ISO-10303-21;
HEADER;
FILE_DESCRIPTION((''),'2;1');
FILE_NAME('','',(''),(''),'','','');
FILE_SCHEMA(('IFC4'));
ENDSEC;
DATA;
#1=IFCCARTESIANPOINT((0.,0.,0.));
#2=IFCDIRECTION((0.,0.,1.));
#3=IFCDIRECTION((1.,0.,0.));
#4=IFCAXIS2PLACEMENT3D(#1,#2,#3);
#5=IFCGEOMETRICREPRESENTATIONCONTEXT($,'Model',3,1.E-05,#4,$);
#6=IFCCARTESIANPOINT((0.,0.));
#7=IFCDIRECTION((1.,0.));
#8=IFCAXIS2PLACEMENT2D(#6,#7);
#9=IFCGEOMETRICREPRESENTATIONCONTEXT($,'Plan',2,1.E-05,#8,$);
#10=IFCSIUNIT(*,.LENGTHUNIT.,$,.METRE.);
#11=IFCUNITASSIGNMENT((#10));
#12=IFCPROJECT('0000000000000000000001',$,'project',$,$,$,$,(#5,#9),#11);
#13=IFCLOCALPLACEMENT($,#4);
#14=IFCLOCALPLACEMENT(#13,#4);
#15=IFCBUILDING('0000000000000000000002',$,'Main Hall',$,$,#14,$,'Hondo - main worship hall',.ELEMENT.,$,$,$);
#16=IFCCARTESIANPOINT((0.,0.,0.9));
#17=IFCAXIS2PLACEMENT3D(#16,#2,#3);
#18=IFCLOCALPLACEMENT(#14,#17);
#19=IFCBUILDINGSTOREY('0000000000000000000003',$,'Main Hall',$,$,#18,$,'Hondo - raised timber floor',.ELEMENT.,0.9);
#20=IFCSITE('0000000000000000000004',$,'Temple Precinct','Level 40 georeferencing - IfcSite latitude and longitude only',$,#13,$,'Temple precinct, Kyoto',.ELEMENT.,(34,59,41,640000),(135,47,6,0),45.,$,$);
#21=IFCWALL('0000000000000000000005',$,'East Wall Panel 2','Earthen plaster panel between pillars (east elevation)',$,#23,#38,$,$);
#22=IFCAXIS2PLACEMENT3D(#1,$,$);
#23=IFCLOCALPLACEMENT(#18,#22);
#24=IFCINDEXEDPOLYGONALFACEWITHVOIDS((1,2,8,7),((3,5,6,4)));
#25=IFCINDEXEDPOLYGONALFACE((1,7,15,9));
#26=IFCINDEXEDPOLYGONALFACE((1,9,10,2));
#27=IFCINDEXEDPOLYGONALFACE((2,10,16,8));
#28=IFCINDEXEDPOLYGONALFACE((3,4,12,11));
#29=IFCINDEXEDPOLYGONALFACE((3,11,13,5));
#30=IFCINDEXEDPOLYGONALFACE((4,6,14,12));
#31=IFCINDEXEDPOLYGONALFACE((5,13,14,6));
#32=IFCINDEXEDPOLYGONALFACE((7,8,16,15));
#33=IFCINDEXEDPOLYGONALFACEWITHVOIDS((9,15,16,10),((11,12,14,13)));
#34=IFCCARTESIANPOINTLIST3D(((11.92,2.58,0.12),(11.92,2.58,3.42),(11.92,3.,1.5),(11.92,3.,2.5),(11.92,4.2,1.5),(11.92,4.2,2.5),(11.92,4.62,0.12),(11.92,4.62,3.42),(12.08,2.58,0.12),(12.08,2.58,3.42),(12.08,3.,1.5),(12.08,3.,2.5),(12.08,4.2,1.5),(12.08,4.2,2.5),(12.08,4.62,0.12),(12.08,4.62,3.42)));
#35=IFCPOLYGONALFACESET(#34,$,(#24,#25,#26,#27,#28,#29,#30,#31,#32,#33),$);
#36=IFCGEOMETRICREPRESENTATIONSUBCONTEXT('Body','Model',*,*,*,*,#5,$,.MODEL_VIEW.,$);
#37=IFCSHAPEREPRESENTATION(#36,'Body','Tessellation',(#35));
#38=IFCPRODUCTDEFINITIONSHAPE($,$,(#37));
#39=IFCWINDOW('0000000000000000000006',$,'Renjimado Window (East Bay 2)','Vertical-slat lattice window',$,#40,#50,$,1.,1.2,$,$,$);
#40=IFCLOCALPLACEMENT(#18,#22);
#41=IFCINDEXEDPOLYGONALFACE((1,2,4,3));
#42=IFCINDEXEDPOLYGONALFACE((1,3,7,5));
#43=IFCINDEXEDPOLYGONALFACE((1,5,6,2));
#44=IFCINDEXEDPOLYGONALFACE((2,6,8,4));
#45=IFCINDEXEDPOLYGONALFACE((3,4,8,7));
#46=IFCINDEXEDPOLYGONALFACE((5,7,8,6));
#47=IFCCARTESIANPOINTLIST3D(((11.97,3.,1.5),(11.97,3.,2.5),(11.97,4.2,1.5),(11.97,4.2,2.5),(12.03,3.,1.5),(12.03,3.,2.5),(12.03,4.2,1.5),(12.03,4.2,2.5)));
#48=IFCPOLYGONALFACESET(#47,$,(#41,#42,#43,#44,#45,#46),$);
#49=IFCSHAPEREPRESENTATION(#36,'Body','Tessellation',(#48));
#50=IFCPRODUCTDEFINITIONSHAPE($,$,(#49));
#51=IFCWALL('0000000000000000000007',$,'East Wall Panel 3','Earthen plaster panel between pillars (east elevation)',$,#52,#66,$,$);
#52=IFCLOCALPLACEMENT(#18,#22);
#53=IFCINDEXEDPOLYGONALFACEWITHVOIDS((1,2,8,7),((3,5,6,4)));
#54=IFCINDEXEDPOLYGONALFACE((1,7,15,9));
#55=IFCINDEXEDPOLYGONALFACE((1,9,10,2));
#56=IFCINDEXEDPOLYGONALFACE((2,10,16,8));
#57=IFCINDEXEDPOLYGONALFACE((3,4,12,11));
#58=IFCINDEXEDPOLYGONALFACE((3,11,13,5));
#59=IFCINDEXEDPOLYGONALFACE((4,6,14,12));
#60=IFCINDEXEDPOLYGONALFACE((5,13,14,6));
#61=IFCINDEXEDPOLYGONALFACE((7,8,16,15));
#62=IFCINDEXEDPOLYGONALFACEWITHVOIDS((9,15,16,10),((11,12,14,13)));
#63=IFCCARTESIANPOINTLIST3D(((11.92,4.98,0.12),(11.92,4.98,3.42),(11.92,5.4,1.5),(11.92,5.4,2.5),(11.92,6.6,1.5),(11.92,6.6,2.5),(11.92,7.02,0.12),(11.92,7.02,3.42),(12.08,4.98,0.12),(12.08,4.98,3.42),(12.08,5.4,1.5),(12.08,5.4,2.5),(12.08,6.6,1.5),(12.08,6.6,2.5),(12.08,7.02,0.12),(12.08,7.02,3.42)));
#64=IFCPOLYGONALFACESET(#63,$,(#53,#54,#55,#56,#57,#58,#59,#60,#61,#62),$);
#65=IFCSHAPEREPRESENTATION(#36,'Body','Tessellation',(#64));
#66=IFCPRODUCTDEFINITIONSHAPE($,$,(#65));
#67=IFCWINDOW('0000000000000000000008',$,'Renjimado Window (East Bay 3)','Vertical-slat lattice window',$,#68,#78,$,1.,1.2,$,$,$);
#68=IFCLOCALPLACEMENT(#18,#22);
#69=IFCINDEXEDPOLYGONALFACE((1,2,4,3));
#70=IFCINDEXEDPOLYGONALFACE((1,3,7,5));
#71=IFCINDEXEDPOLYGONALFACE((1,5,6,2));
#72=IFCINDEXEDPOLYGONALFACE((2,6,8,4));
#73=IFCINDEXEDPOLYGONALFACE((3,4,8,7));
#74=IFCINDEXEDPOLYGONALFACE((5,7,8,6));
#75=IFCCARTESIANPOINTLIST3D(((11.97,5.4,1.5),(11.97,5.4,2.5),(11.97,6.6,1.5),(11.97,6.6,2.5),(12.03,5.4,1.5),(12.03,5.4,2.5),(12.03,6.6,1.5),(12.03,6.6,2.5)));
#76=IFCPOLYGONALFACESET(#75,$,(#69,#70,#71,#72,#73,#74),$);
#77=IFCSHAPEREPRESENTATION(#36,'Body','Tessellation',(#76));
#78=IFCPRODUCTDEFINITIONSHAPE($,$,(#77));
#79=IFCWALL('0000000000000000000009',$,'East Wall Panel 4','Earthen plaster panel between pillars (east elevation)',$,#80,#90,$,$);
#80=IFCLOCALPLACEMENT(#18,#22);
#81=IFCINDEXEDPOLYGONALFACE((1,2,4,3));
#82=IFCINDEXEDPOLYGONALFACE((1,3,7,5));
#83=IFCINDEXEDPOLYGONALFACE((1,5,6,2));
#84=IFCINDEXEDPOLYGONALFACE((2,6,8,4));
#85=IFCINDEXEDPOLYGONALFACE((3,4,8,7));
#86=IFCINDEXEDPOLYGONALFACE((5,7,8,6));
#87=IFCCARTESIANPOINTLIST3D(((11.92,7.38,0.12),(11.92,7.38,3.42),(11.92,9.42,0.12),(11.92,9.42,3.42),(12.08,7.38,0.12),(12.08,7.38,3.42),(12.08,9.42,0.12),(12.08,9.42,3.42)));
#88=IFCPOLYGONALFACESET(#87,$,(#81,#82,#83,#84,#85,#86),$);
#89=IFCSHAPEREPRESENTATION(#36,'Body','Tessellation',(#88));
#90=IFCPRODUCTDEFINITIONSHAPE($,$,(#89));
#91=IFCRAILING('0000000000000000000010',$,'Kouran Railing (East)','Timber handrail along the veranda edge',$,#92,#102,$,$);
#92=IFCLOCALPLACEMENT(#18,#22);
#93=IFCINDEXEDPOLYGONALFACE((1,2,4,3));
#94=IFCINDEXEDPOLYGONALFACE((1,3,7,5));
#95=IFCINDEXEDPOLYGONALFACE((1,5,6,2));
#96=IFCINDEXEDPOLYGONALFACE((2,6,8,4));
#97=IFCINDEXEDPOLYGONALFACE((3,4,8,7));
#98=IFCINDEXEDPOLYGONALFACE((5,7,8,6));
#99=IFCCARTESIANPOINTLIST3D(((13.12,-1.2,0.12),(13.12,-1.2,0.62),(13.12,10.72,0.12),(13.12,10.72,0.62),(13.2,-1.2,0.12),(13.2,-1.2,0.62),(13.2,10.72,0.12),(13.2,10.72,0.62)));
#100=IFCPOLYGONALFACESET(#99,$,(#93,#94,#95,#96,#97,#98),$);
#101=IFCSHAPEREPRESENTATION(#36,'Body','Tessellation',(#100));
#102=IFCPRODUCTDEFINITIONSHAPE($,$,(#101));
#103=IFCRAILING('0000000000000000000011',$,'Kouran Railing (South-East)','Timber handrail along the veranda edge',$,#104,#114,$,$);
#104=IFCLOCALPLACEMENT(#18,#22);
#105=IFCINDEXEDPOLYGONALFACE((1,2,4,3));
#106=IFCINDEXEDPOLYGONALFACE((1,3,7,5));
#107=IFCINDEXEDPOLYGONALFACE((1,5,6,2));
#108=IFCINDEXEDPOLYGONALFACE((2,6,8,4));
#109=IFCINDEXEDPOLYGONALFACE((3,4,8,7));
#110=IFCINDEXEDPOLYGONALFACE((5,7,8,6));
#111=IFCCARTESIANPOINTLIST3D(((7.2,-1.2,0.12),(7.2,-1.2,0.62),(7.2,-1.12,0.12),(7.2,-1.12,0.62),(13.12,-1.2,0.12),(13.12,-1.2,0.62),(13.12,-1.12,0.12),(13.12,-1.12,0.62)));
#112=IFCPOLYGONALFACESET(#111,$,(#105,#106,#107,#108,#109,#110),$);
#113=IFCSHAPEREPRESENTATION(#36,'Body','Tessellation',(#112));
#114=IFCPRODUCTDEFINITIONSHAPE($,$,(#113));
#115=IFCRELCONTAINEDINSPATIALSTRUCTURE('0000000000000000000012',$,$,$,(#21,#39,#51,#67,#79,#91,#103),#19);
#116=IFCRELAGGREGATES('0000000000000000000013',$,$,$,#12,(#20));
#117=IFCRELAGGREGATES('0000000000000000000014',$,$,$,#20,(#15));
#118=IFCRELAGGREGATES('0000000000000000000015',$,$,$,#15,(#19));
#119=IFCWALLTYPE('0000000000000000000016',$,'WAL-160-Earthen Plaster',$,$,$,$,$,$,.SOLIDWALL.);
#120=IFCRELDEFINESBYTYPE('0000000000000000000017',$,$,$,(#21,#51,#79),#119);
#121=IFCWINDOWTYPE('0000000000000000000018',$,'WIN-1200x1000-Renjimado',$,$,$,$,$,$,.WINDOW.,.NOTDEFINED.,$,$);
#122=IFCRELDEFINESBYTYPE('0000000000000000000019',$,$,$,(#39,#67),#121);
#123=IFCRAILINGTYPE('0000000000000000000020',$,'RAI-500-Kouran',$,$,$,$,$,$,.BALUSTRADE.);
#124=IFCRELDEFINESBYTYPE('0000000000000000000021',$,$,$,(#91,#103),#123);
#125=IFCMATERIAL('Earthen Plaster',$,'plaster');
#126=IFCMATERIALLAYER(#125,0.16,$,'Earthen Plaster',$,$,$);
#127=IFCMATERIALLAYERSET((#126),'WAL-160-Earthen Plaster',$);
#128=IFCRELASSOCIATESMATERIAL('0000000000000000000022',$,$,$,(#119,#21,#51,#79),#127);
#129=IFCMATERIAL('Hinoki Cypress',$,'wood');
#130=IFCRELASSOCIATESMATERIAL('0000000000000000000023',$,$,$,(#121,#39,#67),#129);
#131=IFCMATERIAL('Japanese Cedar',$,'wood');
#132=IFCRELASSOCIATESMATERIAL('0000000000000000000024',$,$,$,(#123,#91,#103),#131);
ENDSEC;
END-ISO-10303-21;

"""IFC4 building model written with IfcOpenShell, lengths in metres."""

from ifc_helpers import new_model, si_unit, frame, origin_with_axes, origin_2d_with_axis, place, context, subcontext, project, spatial, line, indexed_curve, outline, extrude, material, layer, layer_set, layer_usage, type_object, element, fill, save


model = new_model("IFC4")

# Units and contexts
model_context = context("Model", 3, precision=1e-05, world=origin_with_axes())
plan_context = context("Plan", 2, precision=1e-05, world=origin_2d_with_axis())
body_context = subcontext(model_context, "Body", "Model", "MODEL_VIEW")
ifc_project = project(units=[si_unit("LENGTHUNIT", "METRE")], contexts=[model_context, plan_context])

# Site, building, storey
site_placement = place(None, origin_with_axes())
site = spatial("IfcSite", under=ifc_project, at=site_placement, Name="Temple Precinct", Description="Level 40 georeferencing - IfcSite latitude and longitude only", LongName="Temple precinct, Kyoto", CompositionType="ELEMENT", RefLatitude=(34, 59, 41, 640000), RefLongitude=(135, 47, 6, 0), RefElevation=45.0)
building_placement = place(site_placement, origin_with_axes())
building = spatial("IfcBuilding", under=site, at=building_placement, Name="Main Hall", LongName="Hondo - main worship hall", CompositionType="ELEMENT")
storey_placement = place(building_placement, frame((0.0, 0.0, 0.9), z_axis=(0.0, 0.0, 1.0), x_axis=(1.0, 0.0, 0.0)))
storey = spatial("IfcBuildingStorey", under=building, at=storey_placement, Name="Main Hall", LongName="Hondo - raised timber floor", CompositionType="ELEMENT", Elevation=0.9)

# Shared definitions
ifc_material_1 = material(Name="Hinoki Cypress", Category="wood")

# Shared definitions
ifc_material_2 = material(Name="Japanese Cedar", Category="wood")

# Shared definitions
ifc_material_3 = material(Name="Earthen Plaster", Category="plaster")
ifc_layer_1 = layer(ifc_material_3, 0.16, Name="Earthen Plaster")
ifc_layer_set_1 = layer_set([ifc_layer_1], Name="WAL-160-Earthen Plaster")
wall_type = type_object("IfcWallType", Name="WAL-160-Earthen Plaster", PredefinedType="SOLIDWALL", material=ifc_layer_set_1)

# Walls, openings, windows
ifc_layer_usage_1 = layer_usage(ifc_layer_set_1, "AXIS2", "POSITIVE", 0.0)
wall_1_placement = place(storey_placement, frame((11.92, 4.62, 0.12), z_axis=(0.0, 0.0, 1.0), x_axis=(0.0, -1.0, 0.0)))
wall_1 = element("IfcWall", 1, at=wall_1_placement, inside=storey, type_object=wall_type, material=ifc_layer_usage_1, Name="East Wall Panel 2", Description="Earthen plaster panel between pillars (east elevation)", context=body_context, shape_type="SweptSolid", body=[
    extrude(outline(indexed_curve([(0.0, 0.0), (0.0, 0.16), (2.04, 0.16), (2.04, 0.0), (0.0, 0.0)], self_intersect=False)), origin_with_axes(), (0.0, 0.0, 1.0), 3.3),
])
opening_1_placement = place(wall_1_placement, frame((1.62, -0.01, 1.38), z_axis=(0.0, 0.0, 1.0), x_axis=(0.0, 1.0, 0.0)))
opening_1 = element("IfcOpeningElement", 2, at=opening_1_placement, cuts=wall_1, PredefinedType="OPENING", context=body_context, shape_type="SweptSolid", body=[
    extrude(outline(indexed_curve([(0.0, 0.0), (0.18, 0.0), (0.18, 1.2), (0.0, 1.2)], segments=[line(1, 2, 3, 4, 1)])), origin_with_axes(), (0.0, 0.0, 1.0), 1.0),
])
window_type = type_object("IfcWindowType", Name="WIN-1200x1000-Renjimado", PartitioningType="NOTDEFINED", PredefinedType="WINDOW", material=ifc_material_1)
window_1_placement = place(storey_placement, frame((11.97, 3.0, 1.5), z_axis=(0.0, 0.0, 1.0), x_axis=(1.0, 0.0, 0.0)))
window_1 = element("IfcWindow", 3, at=window_1_placement, inside=storey, type_object=window_type, material=ifc_material_1, Name="Renjimado Window (East Bay 2)", Description="Vertical-slat lattice window", OverallHeight=1.0, OverallWidth=1.2, context=body_context, shape_type="SweptSolid", body=[
    extrude(outline(indexed_curve([(0.0, 0.0), (0.06, 0.0), (0.06, 1.2), (0.0, 1.2)], segments=[line(1, 2, 3, 4, 1)])), origin_with_axes(), (0.0, 0.0, 1.0), 1.0),
])
fill(opening_1, window_1)
ifc_layer_usage_2 = layer_usage(ifc_layer_set_1, "AXIS2", "POSITIVE", 0.0)
wall_2_placement = place(storey_placement, frame((11.92, 7.02, 0.12), z_axis=(0.0, 0.0, 1.0), x_axis=(0.0, -1.0, 0.0)))
wall_2 = element("IfcWall", 4, at=wall_2_placement, inside=storey, type_object=wall_type, material=ifc_layer_usage_2, Name="East Wall Panel 3", Description="Earthen plaster panel between pillars (east elevation)", context=body_context, shape_type="SweptSolid", body=[
    extrude(outline(indexed_curve([(0.0, 0.0), (0.0, 0.16), (2.04, 0.16), (2.04, 0.0), (0.0, 0.0)], self_intersect=False)), origin_with_axes(), (0.0, 0.0, 1.0), 3.3),
])
opening_2_placement = place(wall_2_placement, frame((1.62, -0.01, 1.38), z_axis=(0.0, 0.0, 1.0), x_axis=(0.0, 1.0, 0.0)))
opening_2 = element("IfcOpeningElement", 5, at=opening_2_placement, cuts=wall_2, PredefinedType="OPENING", context=body_context, shape_type="SweptSolid", body=[
    extrude(outline(indexed_curve([(0.0, 0.0), (0.18, 0.0), (0.18, 1.2), (0.0, 1.2)], segments=[line(1, 2, 3, 4, 1)])), origin_with_axes(), (0.0, 0.0, 1.0), 1.0),
])
window_2_placement = place(storey_placement, frame((11.97, 5.4, 1.5), z_axis=(0.0, 0.0, 1.0), x_axis=(1.0, 0.0, 0.0)))
window_2 = element("IfcWindow", 6, at=window_2_placement, inside=storey, type_object=window_type, material=ifc_material_1, Name="Renjimado Window (East Bay 3)", Description="Vertical-slat lattice window", OverallHeight=1.0, OverallWidth=1.2, context=body_context, shape_type="SweptSolid", body=[
    extrude(outline(indexed_curve([(0.0, 0.0), (0.06, 0.0), (0.06, 1.2), (0.0, 1.2)], segments=[line(1, 2, 3, 4, 1)])), origin_with_axes(), (0.0, 0.0, 1.0), 1.0),
])
fill(opening_2, window_2)

# Wall
ifc_layer_usage_3 = layer_usage(ifc_layer_set_1, "AXIS2", "POSITIVE", 0.0)
wall_3_placement = place(storey_placement, frame((11.92, 9.42, 0.12), z_axis=(0.0, 0.0, 1.0), x_axis=(0.0, -1.0, 0.0)))
element("IfcWall", 7, at=wall_3_placement, inside=storey, type_object=wall_type, material=ifc_layer_usage_3, Name="East Wall Panel 4", Description="Earthen plaster panel between pillars (east elevation)", context=body_context, shape_type="SweptSolid", body=[
    extrude(outline(indexed_curve([(0.0, 0.0), (0.0, 0.16), (2.04, 0.16), (2.04, 0.0), (0.0, 0.0)], self_intersect=False)), origin_with_axes(), (0.0, 0.0, 1.0), 3.3),
])

# Railings
railing_type = type_object("IfcRailingType", Name="RAI-500-Kouran", PredefinedType="BALUSTRADE", material=ifc_material_2)
railing_1_placement = place(storey_placement, frame((13.12, -1.2, 0.12), z_axis=(0.0, 0.0, 1.0), x_axis=(1.0, 0.0, 0.0)))
element("IfcRailing", 8, at=railing_1_placement, inside=storey, type_object=railing_type, material=ifc_material_2, Name="Kouran Railing (East)", Description="Timber handrail along the veranda edge", context=body_context, shape_type="SweptSolid", body=[
    extrude(outline(indexed_curve([(0.0, 0.0), (0.08, 0.0), (0.08, 11.92), (0.0, 11.92)], segments=[line(1, 2, 3, 4, 1)])), origin_with_axes(), (0.0, 0.0, 1.0), 0.5),
])
railing_2_placement = place(storey_placement, frame((7.2, -1.2, 0.12), z_axis=(0.0, 0.0, 1.0), x_axis=(1.0, 0.0, 0.0)))
element("IfcRailing", 9, at=railing_2_placement, inside=storey, type_object=railing_type, material=ifc_material_2, Name="Kouran Railing (South-East)", Description="Timber handrail along the veranda edge", context=body_context, shape_type="SweptSolid", body=[
    extrude(outline(indexed_curve([(0.0, 0.0), (5.92, 0.0), (5.92, 0.08), (0.0, 0.08)], segments=[line(1, 2, 3, 4, 1)])), origin_with_axes(), (0.0, 0.0, 1.0), 0.5),
])

save(model, "model.ifc")
